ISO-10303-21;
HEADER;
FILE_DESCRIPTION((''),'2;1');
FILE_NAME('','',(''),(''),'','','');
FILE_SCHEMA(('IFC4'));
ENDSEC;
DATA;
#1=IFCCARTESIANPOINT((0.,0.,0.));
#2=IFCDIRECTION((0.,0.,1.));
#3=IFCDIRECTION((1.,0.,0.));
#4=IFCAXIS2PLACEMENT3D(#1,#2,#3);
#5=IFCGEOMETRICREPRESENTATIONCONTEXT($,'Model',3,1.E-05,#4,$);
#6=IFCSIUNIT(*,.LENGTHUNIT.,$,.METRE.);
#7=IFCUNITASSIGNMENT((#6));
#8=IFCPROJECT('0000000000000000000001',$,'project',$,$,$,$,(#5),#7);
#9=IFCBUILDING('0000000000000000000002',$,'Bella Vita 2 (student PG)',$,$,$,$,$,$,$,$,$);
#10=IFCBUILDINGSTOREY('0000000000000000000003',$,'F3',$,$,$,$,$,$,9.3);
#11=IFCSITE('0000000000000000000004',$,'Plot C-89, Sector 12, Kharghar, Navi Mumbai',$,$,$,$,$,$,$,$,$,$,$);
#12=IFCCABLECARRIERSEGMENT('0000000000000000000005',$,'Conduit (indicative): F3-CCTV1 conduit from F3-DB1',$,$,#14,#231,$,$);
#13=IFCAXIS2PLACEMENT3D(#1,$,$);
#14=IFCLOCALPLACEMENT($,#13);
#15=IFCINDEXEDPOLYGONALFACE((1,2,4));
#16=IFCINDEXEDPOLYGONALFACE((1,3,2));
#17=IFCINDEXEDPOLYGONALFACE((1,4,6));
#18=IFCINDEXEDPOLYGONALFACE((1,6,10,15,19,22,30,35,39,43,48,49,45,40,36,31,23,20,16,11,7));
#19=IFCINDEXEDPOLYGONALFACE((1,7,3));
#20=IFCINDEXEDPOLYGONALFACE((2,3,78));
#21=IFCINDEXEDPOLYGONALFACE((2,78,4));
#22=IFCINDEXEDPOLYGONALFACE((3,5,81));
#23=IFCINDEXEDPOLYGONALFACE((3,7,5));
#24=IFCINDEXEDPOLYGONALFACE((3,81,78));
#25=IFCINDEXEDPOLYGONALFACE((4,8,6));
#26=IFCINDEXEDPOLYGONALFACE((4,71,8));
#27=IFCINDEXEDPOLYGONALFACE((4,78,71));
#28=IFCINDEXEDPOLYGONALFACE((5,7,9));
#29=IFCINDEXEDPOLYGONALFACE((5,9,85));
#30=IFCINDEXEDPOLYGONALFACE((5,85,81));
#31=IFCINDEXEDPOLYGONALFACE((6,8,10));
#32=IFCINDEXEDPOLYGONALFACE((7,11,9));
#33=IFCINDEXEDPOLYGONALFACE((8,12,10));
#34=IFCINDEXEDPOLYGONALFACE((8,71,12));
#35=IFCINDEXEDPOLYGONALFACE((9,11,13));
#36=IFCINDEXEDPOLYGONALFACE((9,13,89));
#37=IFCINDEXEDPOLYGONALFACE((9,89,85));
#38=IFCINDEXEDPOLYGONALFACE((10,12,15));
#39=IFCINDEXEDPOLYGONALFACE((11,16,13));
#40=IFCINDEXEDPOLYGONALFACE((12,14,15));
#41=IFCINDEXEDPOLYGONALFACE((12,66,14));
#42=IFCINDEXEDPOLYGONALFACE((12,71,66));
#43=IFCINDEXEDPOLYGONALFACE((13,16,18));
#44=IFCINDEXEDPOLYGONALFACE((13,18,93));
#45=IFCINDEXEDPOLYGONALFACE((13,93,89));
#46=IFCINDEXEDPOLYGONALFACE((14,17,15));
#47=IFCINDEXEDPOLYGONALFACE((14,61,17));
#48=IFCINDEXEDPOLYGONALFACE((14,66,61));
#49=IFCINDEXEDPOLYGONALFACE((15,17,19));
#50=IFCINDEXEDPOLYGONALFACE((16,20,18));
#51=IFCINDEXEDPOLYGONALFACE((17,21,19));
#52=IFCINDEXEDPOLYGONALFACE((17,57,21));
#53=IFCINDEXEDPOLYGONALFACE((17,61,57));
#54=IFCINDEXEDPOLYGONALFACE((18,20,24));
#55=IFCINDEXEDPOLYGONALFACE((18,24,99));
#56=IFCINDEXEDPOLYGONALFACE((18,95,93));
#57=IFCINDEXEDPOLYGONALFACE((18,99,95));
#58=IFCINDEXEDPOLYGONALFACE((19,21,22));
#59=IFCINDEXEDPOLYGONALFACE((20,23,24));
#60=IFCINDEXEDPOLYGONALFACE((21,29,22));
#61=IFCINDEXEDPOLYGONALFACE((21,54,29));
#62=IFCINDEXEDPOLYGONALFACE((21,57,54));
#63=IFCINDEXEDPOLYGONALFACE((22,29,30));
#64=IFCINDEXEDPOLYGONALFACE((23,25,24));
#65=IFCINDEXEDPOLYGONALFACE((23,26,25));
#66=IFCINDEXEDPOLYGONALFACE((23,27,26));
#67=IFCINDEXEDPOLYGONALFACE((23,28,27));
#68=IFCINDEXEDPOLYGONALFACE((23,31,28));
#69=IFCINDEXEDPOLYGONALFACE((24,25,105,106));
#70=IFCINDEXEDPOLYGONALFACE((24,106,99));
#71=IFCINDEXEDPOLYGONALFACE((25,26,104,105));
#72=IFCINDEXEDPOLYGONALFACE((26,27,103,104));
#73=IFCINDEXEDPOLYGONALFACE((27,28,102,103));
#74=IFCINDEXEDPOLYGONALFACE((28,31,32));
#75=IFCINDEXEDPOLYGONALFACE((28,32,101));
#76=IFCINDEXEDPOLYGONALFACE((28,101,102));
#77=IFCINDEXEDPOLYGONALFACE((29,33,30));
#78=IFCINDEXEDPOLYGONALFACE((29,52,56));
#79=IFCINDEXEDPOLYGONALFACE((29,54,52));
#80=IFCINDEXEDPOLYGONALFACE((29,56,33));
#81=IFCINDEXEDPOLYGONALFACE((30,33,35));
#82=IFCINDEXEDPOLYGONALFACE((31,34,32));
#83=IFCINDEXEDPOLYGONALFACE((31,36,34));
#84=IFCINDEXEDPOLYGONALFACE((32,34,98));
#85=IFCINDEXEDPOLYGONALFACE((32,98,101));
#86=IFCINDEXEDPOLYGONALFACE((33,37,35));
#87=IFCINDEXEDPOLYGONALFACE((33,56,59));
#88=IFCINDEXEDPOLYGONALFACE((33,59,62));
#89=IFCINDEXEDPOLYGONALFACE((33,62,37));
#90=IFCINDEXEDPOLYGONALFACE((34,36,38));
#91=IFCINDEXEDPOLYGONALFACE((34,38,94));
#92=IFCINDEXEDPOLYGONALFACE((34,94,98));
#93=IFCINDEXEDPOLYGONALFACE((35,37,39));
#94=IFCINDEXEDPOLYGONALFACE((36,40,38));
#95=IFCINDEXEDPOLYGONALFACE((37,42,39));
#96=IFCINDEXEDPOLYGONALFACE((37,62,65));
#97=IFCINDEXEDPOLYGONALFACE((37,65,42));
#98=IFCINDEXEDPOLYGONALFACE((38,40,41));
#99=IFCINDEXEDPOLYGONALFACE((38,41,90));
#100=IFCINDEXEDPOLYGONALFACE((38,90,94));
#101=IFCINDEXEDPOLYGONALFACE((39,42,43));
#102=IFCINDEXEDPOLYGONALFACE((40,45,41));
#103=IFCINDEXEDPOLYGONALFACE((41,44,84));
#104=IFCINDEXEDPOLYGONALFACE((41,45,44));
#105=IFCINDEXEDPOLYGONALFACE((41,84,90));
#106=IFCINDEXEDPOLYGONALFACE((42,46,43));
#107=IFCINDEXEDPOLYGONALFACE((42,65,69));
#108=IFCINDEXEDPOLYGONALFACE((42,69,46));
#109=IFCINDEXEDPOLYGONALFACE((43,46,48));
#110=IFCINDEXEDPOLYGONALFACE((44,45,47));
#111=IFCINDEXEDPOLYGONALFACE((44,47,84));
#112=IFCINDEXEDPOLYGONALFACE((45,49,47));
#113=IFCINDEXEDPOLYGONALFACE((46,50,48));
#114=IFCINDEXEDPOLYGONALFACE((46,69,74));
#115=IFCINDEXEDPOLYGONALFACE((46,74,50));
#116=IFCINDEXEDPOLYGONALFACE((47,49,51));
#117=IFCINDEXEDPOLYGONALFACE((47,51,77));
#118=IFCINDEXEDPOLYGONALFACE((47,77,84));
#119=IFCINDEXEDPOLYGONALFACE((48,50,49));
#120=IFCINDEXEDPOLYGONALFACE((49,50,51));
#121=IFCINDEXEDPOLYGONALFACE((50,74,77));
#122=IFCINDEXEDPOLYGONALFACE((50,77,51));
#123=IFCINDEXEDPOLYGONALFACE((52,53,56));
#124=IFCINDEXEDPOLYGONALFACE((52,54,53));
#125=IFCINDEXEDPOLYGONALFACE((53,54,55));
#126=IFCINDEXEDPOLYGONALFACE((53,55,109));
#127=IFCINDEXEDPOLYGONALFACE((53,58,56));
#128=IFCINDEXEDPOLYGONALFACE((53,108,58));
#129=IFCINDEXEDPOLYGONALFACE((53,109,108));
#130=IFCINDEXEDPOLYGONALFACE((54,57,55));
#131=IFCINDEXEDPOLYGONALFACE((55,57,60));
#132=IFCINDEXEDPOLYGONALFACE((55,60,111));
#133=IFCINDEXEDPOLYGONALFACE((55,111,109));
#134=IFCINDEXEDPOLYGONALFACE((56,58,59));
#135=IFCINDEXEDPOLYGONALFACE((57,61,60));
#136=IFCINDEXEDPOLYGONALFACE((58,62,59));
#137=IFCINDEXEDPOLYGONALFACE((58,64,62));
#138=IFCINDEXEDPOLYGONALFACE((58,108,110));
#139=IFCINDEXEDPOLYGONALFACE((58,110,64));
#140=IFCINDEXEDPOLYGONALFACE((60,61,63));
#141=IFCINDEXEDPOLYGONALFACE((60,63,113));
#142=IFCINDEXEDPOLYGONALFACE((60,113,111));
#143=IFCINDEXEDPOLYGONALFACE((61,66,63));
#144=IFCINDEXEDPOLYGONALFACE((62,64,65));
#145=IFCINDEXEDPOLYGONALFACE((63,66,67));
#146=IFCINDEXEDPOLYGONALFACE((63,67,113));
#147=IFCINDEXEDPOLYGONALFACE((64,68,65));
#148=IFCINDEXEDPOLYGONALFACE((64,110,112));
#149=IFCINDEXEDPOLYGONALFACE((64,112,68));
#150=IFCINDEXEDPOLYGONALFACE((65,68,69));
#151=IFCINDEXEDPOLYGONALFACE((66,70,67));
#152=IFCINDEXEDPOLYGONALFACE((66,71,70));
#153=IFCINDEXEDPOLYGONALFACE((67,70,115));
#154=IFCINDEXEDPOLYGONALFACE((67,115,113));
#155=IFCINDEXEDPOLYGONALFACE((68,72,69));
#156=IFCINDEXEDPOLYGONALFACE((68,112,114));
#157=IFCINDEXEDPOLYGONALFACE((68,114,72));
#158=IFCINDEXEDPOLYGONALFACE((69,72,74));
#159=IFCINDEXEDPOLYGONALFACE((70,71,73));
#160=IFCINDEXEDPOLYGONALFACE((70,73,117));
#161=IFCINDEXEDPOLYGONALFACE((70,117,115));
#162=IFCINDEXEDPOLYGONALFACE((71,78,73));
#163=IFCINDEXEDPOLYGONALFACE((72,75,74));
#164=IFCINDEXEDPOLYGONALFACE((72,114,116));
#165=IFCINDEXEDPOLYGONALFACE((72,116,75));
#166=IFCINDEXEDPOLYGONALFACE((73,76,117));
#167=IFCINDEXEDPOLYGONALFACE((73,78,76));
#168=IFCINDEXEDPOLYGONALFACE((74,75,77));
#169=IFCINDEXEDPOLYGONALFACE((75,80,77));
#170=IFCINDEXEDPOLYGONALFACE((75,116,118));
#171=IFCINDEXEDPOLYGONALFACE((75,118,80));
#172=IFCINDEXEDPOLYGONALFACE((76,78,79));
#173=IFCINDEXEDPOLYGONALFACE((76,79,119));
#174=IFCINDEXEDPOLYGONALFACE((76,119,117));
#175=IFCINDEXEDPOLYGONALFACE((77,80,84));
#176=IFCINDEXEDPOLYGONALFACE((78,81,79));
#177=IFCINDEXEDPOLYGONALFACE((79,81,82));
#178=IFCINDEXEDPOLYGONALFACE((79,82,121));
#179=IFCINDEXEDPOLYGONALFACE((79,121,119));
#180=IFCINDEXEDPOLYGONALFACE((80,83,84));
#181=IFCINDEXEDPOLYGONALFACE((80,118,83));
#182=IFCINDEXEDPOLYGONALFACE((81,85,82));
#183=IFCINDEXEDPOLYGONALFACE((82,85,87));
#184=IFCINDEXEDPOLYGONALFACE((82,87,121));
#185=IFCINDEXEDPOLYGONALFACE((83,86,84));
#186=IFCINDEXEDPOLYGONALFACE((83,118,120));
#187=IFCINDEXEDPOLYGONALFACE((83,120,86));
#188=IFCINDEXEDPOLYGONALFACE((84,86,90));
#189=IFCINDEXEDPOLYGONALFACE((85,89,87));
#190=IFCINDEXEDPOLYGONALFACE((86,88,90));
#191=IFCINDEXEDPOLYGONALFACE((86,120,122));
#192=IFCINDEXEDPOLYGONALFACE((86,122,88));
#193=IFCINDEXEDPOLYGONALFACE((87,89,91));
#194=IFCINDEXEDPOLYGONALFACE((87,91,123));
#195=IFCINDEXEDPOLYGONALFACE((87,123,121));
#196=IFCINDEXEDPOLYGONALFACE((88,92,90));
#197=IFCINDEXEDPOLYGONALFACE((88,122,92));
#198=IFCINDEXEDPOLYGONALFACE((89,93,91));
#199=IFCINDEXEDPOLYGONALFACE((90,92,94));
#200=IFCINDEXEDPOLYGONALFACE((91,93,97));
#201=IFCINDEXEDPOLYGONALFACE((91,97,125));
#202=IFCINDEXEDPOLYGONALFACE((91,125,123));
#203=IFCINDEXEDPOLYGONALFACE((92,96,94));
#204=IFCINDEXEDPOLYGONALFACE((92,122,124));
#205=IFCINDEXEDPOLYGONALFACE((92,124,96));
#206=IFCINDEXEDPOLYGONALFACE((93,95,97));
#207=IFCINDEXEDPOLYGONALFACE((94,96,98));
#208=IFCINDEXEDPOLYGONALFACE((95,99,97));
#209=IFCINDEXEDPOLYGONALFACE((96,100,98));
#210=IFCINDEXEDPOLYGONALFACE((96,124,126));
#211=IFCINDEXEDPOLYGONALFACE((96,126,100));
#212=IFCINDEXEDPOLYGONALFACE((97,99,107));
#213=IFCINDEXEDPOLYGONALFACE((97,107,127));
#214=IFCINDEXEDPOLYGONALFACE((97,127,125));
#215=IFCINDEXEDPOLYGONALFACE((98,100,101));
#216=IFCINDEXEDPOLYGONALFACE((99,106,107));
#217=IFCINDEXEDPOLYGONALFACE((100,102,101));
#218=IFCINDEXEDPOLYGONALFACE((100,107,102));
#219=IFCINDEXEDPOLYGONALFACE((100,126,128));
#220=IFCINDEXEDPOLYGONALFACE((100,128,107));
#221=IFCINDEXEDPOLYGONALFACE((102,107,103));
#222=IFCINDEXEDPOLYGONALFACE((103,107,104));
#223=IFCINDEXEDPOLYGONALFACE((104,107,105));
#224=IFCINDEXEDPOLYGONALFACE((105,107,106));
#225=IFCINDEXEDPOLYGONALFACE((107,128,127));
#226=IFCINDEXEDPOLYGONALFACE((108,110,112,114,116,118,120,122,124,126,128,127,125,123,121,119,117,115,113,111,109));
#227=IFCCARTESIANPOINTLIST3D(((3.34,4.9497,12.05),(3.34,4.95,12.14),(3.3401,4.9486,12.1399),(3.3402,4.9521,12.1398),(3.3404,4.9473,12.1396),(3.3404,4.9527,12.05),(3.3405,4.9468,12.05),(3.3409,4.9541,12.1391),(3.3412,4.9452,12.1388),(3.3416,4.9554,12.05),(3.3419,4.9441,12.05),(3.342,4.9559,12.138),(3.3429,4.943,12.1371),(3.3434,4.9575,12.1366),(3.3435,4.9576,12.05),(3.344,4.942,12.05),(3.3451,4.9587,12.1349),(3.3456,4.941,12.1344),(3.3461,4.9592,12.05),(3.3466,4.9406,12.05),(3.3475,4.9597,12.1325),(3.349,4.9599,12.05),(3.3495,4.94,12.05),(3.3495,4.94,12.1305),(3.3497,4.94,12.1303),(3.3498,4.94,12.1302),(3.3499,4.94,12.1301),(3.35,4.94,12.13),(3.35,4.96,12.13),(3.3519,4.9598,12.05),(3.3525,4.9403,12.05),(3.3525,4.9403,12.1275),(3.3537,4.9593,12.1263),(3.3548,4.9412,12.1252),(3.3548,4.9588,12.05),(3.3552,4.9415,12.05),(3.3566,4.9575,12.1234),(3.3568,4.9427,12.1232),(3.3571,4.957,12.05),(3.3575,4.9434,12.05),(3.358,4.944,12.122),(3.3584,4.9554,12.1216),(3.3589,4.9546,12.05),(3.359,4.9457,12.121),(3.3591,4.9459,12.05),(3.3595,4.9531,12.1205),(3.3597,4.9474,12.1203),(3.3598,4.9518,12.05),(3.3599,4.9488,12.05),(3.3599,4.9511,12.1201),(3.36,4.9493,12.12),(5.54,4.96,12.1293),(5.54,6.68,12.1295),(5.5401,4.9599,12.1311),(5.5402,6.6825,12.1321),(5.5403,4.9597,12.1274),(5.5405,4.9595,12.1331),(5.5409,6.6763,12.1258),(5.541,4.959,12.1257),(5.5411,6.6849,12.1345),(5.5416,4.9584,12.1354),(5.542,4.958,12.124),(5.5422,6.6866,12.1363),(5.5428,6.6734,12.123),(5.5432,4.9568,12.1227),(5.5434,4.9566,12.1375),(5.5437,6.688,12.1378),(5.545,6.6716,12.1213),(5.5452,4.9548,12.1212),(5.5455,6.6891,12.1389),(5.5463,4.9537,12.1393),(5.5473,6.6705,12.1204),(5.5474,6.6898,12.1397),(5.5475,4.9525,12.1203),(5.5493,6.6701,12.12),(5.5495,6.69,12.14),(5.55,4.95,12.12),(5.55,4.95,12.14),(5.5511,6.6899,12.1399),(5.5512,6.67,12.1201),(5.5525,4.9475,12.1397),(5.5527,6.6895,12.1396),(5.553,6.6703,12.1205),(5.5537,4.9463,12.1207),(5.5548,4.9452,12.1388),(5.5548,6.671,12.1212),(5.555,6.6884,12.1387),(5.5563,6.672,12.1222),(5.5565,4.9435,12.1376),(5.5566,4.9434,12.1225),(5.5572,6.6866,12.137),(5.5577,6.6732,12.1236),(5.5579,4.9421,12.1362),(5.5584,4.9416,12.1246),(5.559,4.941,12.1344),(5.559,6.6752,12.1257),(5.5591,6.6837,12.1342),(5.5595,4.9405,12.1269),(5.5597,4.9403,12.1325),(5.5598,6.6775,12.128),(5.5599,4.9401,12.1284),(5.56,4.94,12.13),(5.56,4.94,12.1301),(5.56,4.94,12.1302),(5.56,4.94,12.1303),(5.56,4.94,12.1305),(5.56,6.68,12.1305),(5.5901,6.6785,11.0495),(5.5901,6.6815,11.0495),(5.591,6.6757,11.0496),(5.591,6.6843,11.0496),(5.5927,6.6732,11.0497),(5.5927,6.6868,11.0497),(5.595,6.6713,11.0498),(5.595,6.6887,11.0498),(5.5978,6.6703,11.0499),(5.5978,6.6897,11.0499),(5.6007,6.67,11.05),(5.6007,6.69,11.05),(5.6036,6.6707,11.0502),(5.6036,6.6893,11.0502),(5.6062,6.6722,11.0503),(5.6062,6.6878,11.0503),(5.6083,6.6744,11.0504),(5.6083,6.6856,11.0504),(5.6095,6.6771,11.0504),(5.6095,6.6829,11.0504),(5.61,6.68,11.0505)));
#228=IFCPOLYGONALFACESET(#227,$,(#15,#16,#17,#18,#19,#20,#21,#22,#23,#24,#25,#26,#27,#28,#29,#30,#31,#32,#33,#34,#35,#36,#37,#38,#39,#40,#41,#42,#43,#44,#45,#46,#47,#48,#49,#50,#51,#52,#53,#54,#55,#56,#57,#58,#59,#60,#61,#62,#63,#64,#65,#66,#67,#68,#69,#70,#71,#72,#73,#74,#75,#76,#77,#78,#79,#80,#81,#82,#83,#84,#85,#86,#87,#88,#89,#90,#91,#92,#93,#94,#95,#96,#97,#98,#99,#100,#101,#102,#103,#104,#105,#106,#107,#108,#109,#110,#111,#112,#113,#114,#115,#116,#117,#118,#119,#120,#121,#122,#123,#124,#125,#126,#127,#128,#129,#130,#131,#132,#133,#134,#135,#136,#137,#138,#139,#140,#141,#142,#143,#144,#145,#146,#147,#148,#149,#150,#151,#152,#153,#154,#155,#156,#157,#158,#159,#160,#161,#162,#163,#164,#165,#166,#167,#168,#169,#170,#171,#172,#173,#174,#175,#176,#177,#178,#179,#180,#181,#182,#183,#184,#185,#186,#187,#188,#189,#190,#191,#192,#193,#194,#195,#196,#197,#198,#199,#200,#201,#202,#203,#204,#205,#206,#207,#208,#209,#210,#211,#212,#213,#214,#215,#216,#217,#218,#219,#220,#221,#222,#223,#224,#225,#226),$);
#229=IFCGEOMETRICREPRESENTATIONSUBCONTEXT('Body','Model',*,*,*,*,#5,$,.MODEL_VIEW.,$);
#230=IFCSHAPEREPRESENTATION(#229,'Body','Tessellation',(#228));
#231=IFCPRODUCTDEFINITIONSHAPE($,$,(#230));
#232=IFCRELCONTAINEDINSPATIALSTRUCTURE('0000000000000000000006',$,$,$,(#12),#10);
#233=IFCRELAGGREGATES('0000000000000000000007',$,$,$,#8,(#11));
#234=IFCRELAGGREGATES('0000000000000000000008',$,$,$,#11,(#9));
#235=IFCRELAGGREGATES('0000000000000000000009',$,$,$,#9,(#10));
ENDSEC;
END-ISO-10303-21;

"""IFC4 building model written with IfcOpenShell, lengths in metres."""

from ifc_helpers import new_model, entity, si_unit, origin, origin_with_axes, place, context, subcontext, project, spatial, element, save


model = new_model("IFC4")

# Units and contexts
model_context = context("Model", 3, precision=1e-05, world=origin_with_axes())
body_context = subcontext(model_context, "Body", "Model", "MODEL_VIEW")
ifc_project = project(units=[si_unit("LENGTHUNIT", "METRE")], contexts=[model_context])

# Site, building, storey
site = spatial("IfcSite", under=ifc_project, Name="Plot C-89, Sector 12, Kharghar, Navi Mumbai")
building = spatial("IfcBuilding", under=site, Name="Bella Vita 2 (student PG)")
storey = spatial("IfcBuildingStorey", under=building, Name="F3", Elevation=9.3)

# Cable carrier segment
cable_carrier_segment_1_placement = place(None, origin())
element("IfcCableCarrierSegment", 1, at=cable_carrier_segment_1_placement, inside=storey, Name="Conduit (indicative): F3-CCTV1 conduit from F3-DB1", context=body_context, shape_type="AdvancedSweptSolid", body=[
    entity("IfcSweptDiskSolid", entity("IfcPolyline", [entity("IfcCartesianPoint", [5.6, 6.68, 11.05]), entity("IfcCartesianPoint", [5.55, 6.68, 12.13]), entity("IfcCartesianPoint", [5.55, 4.95, 12.13]), entity("IfcCartesianPoint", [3.35, 4.95, 12.13]), entity("IfcCartesianPoint", [3.35, 4.95, 12.05])]), 0.01),
])

save(model, "model.ifc")
